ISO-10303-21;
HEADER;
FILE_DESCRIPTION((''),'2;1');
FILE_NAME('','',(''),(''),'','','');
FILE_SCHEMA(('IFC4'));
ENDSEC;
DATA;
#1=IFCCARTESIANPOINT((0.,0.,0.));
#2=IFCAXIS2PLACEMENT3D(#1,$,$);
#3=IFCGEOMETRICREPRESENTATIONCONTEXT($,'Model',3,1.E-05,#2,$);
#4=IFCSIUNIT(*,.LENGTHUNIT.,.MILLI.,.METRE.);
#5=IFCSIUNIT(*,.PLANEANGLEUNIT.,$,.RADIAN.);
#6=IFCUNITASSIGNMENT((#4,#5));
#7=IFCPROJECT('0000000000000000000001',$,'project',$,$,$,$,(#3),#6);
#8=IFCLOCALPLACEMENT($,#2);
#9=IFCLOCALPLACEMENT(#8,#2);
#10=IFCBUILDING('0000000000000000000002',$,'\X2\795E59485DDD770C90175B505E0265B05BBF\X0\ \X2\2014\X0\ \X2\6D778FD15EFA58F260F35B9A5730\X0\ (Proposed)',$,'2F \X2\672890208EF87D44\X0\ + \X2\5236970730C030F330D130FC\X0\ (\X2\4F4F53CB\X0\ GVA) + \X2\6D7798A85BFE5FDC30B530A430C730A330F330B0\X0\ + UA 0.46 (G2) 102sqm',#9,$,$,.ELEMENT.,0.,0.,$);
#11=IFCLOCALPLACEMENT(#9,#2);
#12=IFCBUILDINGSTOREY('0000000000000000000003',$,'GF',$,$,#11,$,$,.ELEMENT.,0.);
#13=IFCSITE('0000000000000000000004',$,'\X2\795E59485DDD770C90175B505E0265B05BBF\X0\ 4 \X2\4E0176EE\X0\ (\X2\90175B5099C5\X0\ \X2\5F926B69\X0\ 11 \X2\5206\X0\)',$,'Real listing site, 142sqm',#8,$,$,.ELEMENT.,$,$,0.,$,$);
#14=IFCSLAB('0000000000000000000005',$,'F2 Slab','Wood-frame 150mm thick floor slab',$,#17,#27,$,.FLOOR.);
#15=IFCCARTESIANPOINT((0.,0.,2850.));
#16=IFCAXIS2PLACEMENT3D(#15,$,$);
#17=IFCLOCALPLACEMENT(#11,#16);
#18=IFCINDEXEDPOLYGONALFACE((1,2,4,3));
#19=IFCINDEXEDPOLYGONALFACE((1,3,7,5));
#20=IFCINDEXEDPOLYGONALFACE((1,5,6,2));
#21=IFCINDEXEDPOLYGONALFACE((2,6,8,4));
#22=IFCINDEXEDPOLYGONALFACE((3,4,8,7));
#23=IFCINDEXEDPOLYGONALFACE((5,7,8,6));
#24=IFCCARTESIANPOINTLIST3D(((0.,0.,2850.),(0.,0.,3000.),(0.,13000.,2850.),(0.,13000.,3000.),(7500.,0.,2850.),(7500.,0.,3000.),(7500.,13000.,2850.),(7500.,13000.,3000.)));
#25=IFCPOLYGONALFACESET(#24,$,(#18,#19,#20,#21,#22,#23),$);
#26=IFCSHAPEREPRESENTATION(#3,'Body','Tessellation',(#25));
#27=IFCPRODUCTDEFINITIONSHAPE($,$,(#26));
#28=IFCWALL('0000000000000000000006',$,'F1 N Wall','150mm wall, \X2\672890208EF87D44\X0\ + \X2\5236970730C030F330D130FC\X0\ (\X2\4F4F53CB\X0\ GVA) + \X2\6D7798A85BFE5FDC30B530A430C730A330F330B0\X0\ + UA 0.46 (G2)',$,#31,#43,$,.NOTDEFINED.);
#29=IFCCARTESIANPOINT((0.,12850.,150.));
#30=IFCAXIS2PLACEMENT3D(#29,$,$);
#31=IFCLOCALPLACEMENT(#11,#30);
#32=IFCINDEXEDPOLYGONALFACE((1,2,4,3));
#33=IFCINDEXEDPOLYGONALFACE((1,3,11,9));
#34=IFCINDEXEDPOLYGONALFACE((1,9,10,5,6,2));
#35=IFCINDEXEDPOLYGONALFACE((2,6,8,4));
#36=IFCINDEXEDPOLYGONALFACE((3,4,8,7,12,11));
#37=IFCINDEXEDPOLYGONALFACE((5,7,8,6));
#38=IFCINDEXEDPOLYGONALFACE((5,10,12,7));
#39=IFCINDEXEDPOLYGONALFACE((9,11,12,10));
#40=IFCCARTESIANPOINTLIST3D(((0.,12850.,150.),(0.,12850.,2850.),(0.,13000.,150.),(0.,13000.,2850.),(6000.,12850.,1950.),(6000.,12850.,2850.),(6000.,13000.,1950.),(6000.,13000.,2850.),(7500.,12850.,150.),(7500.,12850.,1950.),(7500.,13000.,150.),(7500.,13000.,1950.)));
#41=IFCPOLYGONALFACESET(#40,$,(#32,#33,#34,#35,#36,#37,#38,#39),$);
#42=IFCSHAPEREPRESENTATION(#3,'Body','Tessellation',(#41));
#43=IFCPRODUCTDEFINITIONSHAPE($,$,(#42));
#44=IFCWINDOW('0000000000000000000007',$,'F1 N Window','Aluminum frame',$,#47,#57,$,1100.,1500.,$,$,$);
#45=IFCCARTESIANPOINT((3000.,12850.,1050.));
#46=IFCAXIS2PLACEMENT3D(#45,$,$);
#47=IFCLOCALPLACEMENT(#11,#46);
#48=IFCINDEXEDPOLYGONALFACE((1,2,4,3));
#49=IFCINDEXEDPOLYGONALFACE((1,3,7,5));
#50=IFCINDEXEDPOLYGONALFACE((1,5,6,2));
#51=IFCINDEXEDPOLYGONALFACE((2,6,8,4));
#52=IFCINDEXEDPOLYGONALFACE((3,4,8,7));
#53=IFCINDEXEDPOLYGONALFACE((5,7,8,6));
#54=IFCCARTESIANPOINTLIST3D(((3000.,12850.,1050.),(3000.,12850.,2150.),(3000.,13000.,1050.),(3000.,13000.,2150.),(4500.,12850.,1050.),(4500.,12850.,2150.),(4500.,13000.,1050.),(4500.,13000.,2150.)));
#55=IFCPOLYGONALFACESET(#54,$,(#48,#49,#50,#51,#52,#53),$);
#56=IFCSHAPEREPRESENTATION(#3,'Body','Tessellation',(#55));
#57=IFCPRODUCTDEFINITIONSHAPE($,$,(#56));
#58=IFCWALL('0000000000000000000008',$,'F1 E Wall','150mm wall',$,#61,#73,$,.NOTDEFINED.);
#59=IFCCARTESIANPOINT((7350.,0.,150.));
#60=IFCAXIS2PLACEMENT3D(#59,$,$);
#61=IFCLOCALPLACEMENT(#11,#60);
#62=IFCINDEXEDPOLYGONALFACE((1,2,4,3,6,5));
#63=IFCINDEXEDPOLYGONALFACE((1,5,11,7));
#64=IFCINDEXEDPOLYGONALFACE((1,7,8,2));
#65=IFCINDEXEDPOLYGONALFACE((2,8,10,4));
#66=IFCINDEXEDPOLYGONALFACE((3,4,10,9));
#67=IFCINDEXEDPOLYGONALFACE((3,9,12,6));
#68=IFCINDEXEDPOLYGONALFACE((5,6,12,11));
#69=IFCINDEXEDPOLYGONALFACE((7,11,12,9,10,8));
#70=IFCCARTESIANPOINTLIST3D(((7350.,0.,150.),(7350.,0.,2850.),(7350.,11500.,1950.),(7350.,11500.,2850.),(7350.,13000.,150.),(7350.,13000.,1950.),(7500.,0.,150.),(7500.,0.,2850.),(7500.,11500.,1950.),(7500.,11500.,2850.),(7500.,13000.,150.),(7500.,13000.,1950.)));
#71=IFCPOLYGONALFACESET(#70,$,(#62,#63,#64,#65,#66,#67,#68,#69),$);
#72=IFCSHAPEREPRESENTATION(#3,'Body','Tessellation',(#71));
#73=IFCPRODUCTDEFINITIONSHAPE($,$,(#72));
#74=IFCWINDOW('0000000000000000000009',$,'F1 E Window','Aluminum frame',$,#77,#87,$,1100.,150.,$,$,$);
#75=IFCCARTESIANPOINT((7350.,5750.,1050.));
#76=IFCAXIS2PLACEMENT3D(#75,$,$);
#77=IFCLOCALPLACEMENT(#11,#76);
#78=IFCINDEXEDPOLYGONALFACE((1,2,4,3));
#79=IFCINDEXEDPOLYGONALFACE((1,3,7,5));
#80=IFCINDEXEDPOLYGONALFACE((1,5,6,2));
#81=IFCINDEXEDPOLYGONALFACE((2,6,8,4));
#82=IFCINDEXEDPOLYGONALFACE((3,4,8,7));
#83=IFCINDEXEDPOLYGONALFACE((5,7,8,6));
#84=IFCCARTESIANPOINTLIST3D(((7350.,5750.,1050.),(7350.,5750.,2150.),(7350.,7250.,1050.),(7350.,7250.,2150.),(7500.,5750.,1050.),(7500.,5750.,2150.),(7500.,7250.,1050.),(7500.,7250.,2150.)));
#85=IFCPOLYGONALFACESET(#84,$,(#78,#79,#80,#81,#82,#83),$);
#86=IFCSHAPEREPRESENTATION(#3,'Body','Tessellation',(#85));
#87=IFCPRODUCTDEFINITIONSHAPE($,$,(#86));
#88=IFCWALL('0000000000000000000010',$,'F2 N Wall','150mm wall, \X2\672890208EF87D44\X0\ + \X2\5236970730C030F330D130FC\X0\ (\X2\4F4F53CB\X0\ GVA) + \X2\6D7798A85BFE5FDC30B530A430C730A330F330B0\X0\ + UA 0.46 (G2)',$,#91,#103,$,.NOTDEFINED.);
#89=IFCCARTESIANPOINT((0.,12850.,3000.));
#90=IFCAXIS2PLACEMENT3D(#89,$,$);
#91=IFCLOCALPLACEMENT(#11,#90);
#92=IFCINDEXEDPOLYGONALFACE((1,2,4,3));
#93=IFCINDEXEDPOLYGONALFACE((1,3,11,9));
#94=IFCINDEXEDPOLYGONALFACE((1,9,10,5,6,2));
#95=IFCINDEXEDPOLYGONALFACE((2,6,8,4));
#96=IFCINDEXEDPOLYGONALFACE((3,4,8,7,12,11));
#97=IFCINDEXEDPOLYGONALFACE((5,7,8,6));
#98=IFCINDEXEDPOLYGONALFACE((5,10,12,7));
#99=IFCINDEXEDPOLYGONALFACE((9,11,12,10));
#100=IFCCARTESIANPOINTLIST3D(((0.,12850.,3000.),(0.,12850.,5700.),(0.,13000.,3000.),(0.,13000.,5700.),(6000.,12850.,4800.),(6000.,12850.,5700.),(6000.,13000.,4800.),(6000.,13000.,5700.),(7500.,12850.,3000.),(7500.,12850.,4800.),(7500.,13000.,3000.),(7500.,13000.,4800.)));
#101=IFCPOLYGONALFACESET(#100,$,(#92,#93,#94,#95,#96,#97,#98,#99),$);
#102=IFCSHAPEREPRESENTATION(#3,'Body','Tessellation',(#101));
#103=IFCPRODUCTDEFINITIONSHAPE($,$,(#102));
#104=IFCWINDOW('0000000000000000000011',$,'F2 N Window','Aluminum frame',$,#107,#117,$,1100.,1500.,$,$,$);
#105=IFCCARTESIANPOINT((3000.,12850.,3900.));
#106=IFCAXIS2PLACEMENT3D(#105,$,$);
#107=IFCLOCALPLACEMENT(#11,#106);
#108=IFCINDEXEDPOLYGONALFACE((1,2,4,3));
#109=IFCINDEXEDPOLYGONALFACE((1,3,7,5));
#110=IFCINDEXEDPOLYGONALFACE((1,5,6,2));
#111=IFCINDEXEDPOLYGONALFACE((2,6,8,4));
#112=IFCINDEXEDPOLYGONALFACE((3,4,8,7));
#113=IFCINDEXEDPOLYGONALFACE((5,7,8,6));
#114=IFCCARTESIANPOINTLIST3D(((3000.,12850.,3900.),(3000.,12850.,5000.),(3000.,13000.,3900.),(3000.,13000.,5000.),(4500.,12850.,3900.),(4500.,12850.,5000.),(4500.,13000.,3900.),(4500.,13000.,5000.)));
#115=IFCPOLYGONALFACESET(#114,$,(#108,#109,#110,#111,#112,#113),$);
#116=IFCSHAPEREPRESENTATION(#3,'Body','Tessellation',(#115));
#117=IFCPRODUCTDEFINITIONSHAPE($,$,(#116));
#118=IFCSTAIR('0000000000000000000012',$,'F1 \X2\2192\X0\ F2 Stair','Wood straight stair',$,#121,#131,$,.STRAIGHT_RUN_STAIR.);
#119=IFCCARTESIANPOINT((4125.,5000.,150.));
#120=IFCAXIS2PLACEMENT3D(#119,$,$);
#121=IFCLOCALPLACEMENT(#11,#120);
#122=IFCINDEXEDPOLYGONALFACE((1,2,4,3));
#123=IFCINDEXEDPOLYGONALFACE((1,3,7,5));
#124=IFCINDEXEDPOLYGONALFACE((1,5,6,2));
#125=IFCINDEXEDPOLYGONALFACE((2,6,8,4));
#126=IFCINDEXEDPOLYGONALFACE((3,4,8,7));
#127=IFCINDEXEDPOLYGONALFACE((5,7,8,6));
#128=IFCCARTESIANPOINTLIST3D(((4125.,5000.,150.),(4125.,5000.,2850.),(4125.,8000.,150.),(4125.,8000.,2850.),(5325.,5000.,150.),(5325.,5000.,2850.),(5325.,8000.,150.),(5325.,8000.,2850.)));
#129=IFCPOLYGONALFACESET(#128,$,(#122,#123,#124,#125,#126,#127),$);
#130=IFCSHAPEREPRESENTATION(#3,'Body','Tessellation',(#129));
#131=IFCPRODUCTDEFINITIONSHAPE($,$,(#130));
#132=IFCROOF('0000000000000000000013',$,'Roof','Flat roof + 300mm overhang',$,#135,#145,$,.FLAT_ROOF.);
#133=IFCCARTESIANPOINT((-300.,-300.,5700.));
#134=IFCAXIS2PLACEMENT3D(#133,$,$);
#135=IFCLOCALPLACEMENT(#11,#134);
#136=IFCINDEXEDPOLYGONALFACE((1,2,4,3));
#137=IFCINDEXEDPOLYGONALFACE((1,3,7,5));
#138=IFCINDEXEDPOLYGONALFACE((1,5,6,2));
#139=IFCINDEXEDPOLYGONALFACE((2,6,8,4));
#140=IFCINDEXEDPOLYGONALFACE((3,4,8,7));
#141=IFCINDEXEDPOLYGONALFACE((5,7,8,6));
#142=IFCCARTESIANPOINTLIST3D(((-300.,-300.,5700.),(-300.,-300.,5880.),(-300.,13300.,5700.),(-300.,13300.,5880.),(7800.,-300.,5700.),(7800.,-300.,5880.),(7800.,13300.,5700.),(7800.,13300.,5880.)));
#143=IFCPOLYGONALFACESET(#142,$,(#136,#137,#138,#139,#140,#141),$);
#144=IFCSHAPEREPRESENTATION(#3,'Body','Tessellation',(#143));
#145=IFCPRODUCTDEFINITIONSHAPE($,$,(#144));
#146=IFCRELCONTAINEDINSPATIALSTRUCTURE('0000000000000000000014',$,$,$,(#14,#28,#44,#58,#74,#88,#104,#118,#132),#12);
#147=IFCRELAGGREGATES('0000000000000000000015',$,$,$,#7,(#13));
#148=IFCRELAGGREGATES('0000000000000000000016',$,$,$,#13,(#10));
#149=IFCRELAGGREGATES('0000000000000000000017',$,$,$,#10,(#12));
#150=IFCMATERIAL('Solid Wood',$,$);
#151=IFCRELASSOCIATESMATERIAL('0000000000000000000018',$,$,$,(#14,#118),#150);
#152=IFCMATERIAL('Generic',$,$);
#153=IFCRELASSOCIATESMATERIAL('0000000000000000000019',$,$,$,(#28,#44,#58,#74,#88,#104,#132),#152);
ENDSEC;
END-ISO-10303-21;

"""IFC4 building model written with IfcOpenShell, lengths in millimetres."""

from ifc_helpers import new_model, si_unit, frame, frame_2d, origin, place, context, project, spatial, rectangle, extrude, material, element, fill, save


model = new_model("IFC4")

# Units and contexts
model_context = context("Model", 3, precision=1e-05, world=origin())
ifc_project = project(units=[si_unit("LENGTHUNIT", "METRE", prefix="MILLI"), si_unit("PLANEANGLEUNIT", "RADIAN")], contexts=[model_context])

# Site, building, storey
site_placement = place(None, origin())
site = spatial("IfcSite", under=ifc_project, at=site_placement, Name="神奈川県逗子市新宿 4 丁目 (逗子駅 徒歩 11 分)", ObjectType="Real listing site, 142sqm", CompositionType="ELEMENT", RefElevation=0.0)
building_placement = place(site_placement, origin())
building = spatial("IfcBuilding", under=site, at=building_placement, Name="神奈川県逗子市新宿 — 海近建売想定地 (Proposed)", ObjectType="2F 木造軸組 + 制震ダンパー (住友 GVA) + 海風対応サイディング + UA 0.46 (G2) 102sqm", CompositionType="ELEMENT", ElevationOfRefHeight=0.0, ElevationOfTerrain=0.0)
storey_placement = place(building_placement, origin())
storey = spatial("IfcBuildingStorey", under=building, at=storey_placement, Name="GF", CompositionType="ELEMENT", Elevation=0.0)

# Slab
ifc_material_1 = material(Name="Solid Wood")
slab_1_placement = place(storey_placement, frame((0.0, 0.0, 2850.0)))
element("IfcSlab", 1, at=slab_1_placement, inside=storey, material=ifc_material_1, Name="F2 Slab", Description="Wood-frame 150mm thick floor slab", PredefinedType="FLOOR", context=model_context, shape_type="SweptSolid", body=[
    extrude(rectangle(XDim=7500.0, YDim=13000.0, at=frame_2d((3750.0, 6500.0))), frame((0.0, 0.0, 2850.0)), (0.0, 0.0, 1.0), 150.0),
])

# Wall, opening, window
ifc_material_2 = material(Name="Generic")
wall_1_placement = place(storey_placement, frame((0.0, 12850.0, 150.0)))
wall_1 = element("IfcWall", 2, at=wall_1_placement, inside=storey, material=ifc_material_2, Name="F1 N Wall", Description="150mm wall, 木造軸組 + 制震ダンパー (住友 GVA) + 海風対応サイディング + UA 0.46 (G2)", PredefinedType="NOTDEFINED", context=model_context, shape_type="SweptSolid", body=[
    extrude(rectangle(XDim=7500.0, YDim=150.0, at=frame_2d((3750.0, 75.0))), frame((0.0, 12850.0, 150.0)), (0.0, 0.0, 1.0), 2700.0),
])
opening_1_placement = place(storey_placement, frame((3000.0, 12850.0, 1050.0)))
opening_1 = element("IfcOpeningElement", 3, at=opening_1_placement, cuts=wall_1, PredefinedType="NOTDEFINED", context=model_context, shape_type="SweptSolid", body=[
    extrude(rectangle(XDim=1500.0, YDim=150.0, at=frame_2d((750.0, 75.0))), frame((3000.0, 12850.0, 1050.0)), (0.0, 0.0, 1.0), 1100.0),
])
window_1_placement = place(storey_placement, frame((3000.0, 12850.0, 1050.0)))
window_1 = element("IfcWindow", 4, at=window_1_placement, inside=storey, material=ifc_material_2, Name="F1 N Window", Description="Aluminum frame", OverallHeight=1100.0, OverallWidth=1500.0, context=model_context, shape_type="SweptSolid", body=[
    extrude(rectangle(XDim=1500.0, YDim=150.0, at=frame_2d((750.0, 75.0))), frame((3000.0, 12850.0, 1050.0)), (0.0, 0.0, 1.0), 1100.0),
])
fill(opening_1, window_1)

# Walls, openings, windows
wall_2_placement = place(storey_placement, frame((7350.0, 0.0, 150.0)))
wall_2 = element("IfcWall", 5, at=wall_2_placement, inside=storey, material=ifc_material_2, Name="F1 E Wall", Description="150mm wall", PredefinedType="NOTDEFINED", context=model_context, shape_type="SweptSolid", body=[
    extrude(rectangle(XDim=150.0, YDim=13000.0, at=frame_2d((75.0, 6500.0))), frame((7350.0, 0.0, 150.0)), (0.0, 0.0, 1.0), 2700.0),
])
opening_2_placement = place(storey_placement, frame((7350.0, 5750.0, 1050.0)))
opening_2 = element("IfcOpeningElement", 6, at=opening_2_placement, cuts=wall_2, PredefinedType="NOTDEFINED", context=model_context, shape_type="SweptSolid", body=[
    extrude(rectangle(XDim=150.0, YDim=1500.0, at=frame_2d((75.0, 750.0))), frame((7350.0, 5750.0, 1050.0)), (0.0, 0.0, 1.0), 1100.0),
])
window_2_placement = place(storey_placement, frame((7350.0, 5750.0, 1050.0)))
window_2 = element("IfcWindow", 7, at=window_2_placement, inside=storey, material=ifc_material_2, Name="F1 E Window", Description="Aluminum frame", OverallHeight=1100.0, OverallWidth=150.0, context=model_context, shape_type="SweptSolid", body=[
    extrude(rectangle(XDim=150.0, YDim=1500.0, at=frame_2d((75.0, 750.0))), frame((7350.0, 5750.0, 1050.0)), (0.0, 0.0, 1.0), 1100.0),
])
fill(opening_2, window_2)
wall_3_placement = place(storey_placement, frame((0.0, 12850.0, 3000.0)))
wall_3 = element("IfcWall", 8, at=wall_3_placement, inside=storey, material=ifc_material_2, Name="F2 N Wall", Description="150mm wall, 木造軸組 + 制震ダンパー (住友 GVA) + 海風対応サイディング + UA 0.46 (G2)", PredefinedType="NOTDEFINED", context=model_context, shape_type="SweptSolid", body=[
    extrude(rectangle(XDim=7500.0, YDim=150.0, at=frame_2d((3750.0, 75.0))), frame((0.0, 12850.0, 3000.0)), (0.0, 0.0, 1.0), 2700.0),
])
opening_3_placement = place(storey_placement, frame((3000.0, 12850.0, 3900.0)))
opening_3 = element("IfcOpeningElement", 9, at=opening_3_placement, cuts=wall_3, PredefinedType="NOTDEFINED", context=model_context, shape_type="SweptSolid", body=[
    extrude(rectangle(XDim=1500.0, YDim=150.0, at=frame_2d((750.0, 75.0))), frame((3000.0, 12850.0, 3900.0)), (0.0, 0.0, 1.0), 1100.0),
])
window_3_placement = place(storey_placement, frame((3000.0, 12850.0, 3900.0)))
window_3 = element("IfcWindow", 10, at=window_3_placement, inside=storey, material=ifc_material_2, Name="F2 N Window", Description="Aluminum frame", OverallHeight=1100.0, OverallWidth=1500.0, context=model_context, shape_type="SweptSolid", body=[
    extrude(rectangle(XDim=1500.0, YDim=150.0, at=frame_2d((750.0, 75.0))), frame((3000.0, 12850.0, 3900.0)), (0.0, 0.0, 1.0), 1100.0),
])
fill(opening_3, window_3)

# Stair
stair_placement = place(storey_placement, frame((4125.0, 5000.0, 150.0)))
element("IfcStair", 11, at=stair_placement, inside=storey, material=ifc_material_1, Name="F1 → F2 Stair", Description="Wood straight stair", PredefinedType="STRAIGHT_RUN_STAIR", context=model_context, shape_type="SweptSolid", body=[
    extrude(rectangle(XDim=1200.0, YDim=3000.0, at=frame_2d((600.0, 1500.0))), frame((4125.0, 5000.0, 150.0)), (0.0, 0.0, 1.0), 2700.0),
])

# Roof
roof_placement = place(storey_placement, frame((-300.0, -300.0, 5700.0)))
element("IfcRoof", 12, at=roof_placement, inside=storey, material=ifc_material_2, Name="Roof", Description="Flat roof + 300mm overhang", PredefinedType="FLAT_ROOF", context=model_context, shape_type="SweptSolid", body=[
    extrude(rectangle(XDim=8100.0, YDim=13600.0, at=frame_2d((4050.0, 6800.0))), frame((-300.0, -300.0, 5700.0)), (0.0, 0.0, 1.0), 180.0),
])

save(model, "model.ifc")
